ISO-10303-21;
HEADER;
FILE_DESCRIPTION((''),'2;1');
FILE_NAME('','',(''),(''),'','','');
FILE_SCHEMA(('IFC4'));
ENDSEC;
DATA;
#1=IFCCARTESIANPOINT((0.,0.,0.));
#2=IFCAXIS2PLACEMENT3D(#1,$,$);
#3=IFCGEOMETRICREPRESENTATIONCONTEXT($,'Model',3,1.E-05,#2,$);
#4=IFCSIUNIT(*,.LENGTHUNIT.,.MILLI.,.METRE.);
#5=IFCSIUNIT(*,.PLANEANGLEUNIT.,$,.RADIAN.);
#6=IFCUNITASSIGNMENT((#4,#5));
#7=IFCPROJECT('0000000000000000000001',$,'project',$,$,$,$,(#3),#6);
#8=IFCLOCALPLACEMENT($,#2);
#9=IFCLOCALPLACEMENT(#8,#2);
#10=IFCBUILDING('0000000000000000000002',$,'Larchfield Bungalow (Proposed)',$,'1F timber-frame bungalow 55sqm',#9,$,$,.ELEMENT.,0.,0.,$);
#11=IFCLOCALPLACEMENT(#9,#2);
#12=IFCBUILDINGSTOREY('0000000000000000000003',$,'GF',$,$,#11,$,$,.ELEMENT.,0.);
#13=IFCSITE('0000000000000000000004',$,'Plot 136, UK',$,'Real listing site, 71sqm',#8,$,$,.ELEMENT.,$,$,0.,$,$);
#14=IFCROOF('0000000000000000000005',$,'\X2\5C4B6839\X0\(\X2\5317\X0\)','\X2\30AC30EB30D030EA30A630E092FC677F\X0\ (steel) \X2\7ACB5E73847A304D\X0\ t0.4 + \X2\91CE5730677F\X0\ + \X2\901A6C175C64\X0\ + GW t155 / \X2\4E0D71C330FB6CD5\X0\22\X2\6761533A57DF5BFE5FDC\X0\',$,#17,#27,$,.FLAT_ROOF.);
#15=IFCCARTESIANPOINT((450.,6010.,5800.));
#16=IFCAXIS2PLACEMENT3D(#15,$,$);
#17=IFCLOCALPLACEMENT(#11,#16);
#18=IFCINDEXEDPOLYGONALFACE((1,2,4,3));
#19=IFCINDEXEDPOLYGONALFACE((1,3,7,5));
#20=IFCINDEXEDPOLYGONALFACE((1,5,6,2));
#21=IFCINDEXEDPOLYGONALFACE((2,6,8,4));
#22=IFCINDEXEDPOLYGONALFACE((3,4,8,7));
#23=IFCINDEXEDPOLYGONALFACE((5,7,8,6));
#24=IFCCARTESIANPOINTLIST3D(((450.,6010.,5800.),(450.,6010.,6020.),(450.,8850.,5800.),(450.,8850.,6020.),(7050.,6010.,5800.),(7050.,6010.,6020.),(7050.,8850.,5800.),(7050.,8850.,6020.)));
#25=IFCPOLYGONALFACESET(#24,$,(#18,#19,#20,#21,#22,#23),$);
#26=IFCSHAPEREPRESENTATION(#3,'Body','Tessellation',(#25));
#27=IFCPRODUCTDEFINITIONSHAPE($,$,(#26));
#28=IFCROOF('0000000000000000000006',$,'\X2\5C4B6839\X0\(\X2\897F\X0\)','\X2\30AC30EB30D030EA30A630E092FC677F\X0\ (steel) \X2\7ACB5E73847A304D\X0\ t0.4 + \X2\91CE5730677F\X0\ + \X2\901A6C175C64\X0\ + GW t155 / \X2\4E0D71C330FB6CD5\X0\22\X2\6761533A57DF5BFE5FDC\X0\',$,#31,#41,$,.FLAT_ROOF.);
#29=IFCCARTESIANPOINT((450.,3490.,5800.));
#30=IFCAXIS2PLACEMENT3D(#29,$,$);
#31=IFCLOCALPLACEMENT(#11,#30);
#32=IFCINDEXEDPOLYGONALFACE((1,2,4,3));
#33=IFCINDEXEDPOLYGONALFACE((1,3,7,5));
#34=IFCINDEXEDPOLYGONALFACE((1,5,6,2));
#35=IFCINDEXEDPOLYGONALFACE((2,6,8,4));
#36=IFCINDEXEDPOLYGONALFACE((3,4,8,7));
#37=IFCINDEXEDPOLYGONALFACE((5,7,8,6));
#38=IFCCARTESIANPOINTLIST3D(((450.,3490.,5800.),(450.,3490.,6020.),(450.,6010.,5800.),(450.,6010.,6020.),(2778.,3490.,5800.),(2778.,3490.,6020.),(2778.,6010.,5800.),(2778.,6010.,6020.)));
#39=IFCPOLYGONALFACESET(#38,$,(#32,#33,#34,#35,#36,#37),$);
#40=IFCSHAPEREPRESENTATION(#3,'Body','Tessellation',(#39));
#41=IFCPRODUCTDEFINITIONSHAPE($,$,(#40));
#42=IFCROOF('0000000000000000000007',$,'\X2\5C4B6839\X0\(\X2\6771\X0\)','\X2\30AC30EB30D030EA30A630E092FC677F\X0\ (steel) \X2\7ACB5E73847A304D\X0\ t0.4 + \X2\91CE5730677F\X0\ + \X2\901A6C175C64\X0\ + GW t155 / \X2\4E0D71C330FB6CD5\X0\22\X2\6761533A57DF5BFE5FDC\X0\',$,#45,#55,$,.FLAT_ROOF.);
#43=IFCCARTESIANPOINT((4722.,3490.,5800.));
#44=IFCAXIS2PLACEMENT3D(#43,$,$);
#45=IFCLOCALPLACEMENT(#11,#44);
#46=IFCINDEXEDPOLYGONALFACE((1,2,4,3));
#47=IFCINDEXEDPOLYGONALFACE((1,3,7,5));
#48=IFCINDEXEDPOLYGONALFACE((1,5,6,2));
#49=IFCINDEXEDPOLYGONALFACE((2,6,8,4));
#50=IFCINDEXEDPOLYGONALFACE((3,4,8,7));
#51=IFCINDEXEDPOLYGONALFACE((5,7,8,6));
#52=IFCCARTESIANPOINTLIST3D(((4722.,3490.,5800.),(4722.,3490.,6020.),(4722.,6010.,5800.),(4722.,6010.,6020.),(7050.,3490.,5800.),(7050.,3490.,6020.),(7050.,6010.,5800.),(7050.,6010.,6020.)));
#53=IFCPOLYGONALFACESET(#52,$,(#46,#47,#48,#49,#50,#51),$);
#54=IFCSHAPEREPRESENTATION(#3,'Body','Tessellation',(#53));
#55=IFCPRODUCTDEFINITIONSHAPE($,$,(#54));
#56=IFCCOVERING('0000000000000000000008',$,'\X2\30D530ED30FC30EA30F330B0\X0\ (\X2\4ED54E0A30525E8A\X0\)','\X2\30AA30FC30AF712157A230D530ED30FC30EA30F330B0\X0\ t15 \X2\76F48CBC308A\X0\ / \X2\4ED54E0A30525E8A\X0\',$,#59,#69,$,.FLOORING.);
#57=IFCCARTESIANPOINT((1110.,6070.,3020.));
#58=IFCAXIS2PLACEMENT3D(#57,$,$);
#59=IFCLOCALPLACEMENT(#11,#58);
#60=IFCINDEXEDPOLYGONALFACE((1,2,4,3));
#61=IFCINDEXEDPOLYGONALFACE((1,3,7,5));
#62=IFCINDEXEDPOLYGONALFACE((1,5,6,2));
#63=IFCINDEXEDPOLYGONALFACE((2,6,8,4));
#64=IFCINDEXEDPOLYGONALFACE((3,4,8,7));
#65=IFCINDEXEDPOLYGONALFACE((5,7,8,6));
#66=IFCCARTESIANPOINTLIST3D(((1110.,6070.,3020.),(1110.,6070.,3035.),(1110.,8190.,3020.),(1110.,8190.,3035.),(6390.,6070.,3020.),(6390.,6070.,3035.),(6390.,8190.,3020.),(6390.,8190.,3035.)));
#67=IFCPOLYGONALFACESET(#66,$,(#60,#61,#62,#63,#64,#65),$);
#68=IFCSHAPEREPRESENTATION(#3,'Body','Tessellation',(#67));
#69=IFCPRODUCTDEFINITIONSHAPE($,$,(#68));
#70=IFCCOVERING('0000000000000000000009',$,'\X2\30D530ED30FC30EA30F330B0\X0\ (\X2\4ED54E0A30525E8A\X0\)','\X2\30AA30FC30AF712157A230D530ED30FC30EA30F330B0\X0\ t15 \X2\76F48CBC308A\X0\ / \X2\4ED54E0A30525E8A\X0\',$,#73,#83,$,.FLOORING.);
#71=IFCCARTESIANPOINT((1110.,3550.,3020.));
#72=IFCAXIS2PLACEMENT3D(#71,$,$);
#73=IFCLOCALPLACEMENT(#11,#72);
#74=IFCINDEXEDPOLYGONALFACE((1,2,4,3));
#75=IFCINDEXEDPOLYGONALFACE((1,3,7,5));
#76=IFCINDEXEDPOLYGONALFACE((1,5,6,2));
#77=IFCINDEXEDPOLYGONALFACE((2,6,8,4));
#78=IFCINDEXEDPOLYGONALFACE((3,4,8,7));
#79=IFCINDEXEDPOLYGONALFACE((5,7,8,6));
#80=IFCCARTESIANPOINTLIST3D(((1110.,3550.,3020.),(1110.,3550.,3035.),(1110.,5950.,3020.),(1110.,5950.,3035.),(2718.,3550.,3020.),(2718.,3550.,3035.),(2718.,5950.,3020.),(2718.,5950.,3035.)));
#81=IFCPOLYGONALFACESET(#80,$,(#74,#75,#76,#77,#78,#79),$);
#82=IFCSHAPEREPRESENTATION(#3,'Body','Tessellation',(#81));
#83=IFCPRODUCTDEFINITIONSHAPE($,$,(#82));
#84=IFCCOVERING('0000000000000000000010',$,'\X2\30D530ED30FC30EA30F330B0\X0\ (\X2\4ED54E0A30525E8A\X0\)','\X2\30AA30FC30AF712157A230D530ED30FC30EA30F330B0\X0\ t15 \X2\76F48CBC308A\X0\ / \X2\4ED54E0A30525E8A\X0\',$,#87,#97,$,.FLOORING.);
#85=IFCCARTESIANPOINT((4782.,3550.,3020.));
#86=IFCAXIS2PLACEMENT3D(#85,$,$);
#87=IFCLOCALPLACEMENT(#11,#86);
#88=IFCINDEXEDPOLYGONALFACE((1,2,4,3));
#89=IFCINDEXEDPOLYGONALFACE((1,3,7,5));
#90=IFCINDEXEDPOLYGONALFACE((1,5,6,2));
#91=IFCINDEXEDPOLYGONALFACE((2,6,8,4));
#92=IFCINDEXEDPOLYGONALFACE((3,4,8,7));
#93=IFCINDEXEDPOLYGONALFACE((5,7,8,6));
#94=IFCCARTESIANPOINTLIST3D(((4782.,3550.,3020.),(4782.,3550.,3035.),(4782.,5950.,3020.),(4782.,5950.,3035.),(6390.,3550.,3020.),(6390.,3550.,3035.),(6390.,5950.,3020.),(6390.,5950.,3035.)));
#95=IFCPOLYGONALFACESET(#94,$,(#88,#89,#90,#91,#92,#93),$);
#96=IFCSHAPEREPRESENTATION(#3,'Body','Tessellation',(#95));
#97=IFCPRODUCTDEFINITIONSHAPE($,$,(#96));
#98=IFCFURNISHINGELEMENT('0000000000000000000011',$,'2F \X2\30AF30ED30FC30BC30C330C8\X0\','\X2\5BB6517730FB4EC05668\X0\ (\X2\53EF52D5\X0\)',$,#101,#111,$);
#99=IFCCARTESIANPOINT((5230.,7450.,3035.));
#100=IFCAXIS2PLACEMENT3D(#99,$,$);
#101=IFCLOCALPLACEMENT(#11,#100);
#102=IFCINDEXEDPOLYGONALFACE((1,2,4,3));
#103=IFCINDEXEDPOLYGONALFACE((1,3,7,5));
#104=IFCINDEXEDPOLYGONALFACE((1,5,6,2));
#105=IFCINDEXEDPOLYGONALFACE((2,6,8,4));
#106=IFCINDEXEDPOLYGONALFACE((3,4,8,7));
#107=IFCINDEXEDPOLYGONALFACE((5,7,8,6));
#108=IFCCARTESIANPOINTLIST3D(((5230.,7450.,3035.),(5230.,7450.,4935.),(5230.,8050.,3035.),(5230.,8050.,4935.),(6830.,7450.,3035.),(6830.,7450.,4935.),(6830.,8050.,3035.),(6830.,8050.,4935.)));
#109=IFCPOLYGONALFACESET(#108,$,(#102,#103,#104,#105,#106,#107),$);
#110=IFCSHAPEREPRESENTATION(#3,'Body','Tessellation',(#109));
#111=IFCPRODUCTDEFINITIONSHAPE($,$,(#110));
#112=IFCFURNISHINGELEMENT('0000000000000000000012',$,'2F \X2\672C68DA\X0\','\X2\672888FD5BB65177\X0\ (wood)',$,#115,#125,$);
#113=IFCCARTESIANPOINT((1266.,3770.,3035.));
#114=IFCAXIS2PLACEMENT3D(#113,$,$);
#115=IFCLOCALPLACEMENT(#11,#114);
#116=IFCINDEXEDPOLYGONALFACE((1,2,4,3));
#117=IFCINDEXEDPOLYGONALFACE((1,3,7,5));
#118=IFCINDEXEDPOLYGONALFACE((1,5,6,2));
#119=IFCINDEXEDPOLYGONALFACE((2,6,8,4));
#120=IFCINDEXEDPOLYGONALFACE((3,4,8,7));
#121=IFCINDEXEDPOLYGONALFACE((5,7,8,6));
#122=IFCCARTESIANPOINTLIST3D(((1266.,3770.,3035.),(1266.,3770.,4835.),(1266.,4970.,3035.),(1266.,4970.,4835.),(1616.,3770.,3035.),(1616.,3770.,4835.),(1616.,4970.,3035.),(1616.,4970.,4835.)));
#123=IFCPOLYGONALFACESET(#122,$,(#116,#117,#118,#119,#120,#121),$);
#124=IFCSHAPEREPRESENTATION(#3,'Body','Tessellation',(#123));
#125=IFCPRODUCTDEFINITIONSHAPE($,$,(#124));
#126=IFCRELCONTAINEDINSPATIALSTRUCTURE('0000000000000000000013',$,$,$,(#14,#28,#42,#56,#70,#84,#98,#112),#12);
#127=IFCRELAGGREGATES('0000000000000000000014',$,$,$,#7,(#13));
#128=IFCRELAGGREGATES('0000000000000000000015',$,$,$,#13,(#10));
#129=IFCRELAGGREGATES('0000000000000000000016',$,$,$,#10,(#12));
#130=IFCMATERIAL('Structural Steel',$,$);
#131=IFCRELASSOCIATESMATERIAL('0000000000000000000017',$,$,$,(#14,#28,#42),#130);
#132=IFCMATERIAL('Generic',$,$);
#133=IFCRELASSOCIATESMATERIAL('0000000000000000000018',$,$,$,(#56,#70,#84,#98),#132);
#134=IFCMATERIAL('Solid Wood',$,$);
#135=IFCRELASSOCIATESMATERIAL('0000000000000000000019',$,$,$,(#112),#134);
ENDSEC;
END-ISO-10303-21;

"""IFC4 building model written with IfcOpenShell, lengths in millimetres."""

from ifc_helpers import new_model, si_unit, frame, frame_2d, origin, place, context, project, spatial, rectangle, extrude, material, element, save


model = new_model("IFC4")

# Units and contexts
model_context = context("Model", 3, precision=1e-05, world=origin())
ifc_project = project(units=[si_unit("LENGTHUNIT", "METRE", prefix="MILLI"), si_unit("PLANEANGLEUNIT", "RADIAN")], contexts=[model_context])

# Site, building, storey
site_placement = place(None, origin())
site = spatial("IfcSite", under=ifc_project, at=site_placement, Name="Plot 136, UK", ObjectType="Real listing site, 71sqm", CompositionType="ELEMENT", RefElevation=0.0)
building_placement = place(site_placement, origin())
building = spatial("IfcBuilding", under=site, at=building_placement, Name="Larchfield Bungalow (Proposed)", ObjectType="1F timber-frame bungalow 55sqm", CompositionType="ELEMENT", ElevationOfRefHeight=0.0, ElevationOfTerrain=0.0)
storey_placement = place(building_placement, origin())
storey = spatial("IfcBuildingStorey", under=building, at=storey_placement, Name="GF", CompositionType="ELEMENT", Elevation=0.0)

# Shared definitions
ifc_material_1 = material(Name="Solid Wood")

# Shared definitions
ifc_material_2 = material(Name="Generic")

# Roofs
ifc_material_3 = material(Name="Structural Steel")
for number, where, name in (
    (1, (450.0, 6010.0, 5800.0), "屋根(北)"),
):
    element("IfcRoof", number, at=place(storey_placement, frame(where)), inside=storey, material=ifc_material_3, Name=name, Description="ガルバリウム鋼板 (steel) 立平葺き t0.4 + 野地板 + 通気層 + GW t155 / 不燃・法22条区域対応", PredefinedType="FLAT_ROOF", context=model_context, shape_type="SweptSolid", body=[
        extrude(rectangle(XDim=6600.0, YDim=2840.0, at=frame_2d((3300.0, 1420.0))), frame((450.0, 6010.0, 5800.0)), (0.0, 0.0, 1.0), 220.0),
    ])
roof_1_placement = place(storey_placement, frame((450.0, 3490.0, 5800.0)))
element("IfcRoof", 2, at=roof_1_placement, inside=storey, material=ifc_material_3, Name="屋根(西)", Description="ガルバリウム鋼板 (steel) 立平葺き t0.4 + 野地板 + 通気層 + GW t155 / 不燃・法22条区域対応", PredefinedType="FLAT_ROOF", context=model_context, shape_type="SweptSolid", body=[
    extrude(rectangle(XDim=2328.0, YDim=2520.0, at=frame_2d((1164.0, 1260.0))), frame((450.0, 3490.0, 5800.0)), (0.0, 0.0, 1.0), 220.0),
])
roof_2_placement = place(storey_placement, frame((4722.0, 3490.0, 5800.0)))
element("IfcRoof", 3, at=roof_2_placement, inside=storey, material=ifc_material_3, Name="屋根(東)", Description="ガルバリウム鋼板 (steel) 立平葺き t0.4 + 野地板 + 通気層 + GW t155 / 不燃・法22条区域対応", PredefinedType="FLAT_ROOF", context=model_context, shape_type="SweptSolid", body=[
    extrude(rectangle(XDim=2328.0, YDim=2520.0, at=frame_2d((1164.0, 1260.0))), frame((4722.0, 3490.0, 5800.0)), (0.0, 0.0, 1.0), 220.0),
])

# Coverings
covering_1_placement = place(storey_placement, frame((1110.0, 6070.0, 3020.0)))
element("IfcCovering", 4, at=covering_1_placement, inside=storey, material=ifc_material_2, Name="フローリング (仕上げ床)", Description="オーク無垢フローリング t15 直貼り / 仕上げ床", PredefinedType="FLOORING", context=model_context, shape_type="SweptSolid", body=[
    extrude(rectangle(XDim=5280.0, YDim=2120.0, at=frame_2d((2640.0, 1060.0))), frame((1110.0, 6070.0, 3020.0)), (0.0, 0.0, 1.0), 15.0),
])
covering_2_placement = place(storey_placement, frame((1110.0, 3550.0, 3020.0)))
element("IfcCovering", 5, at=covering_2_placement, inside=storey, material=ifc_material_2, Name="フローリング (仕上げ床)", Description="オーク無垢フローリング t15 直貼り / 仕上げ床", PredefinedType="FLOORING", context=model_context, shape_type="SweptSolid", body=[
    extrude(rectangle(XDim=1608.0, YDim=2400.0, at=frame_2d((804.0, 1200.0))), frame((1110.0, 3550.0, 3020.0)), (0.0, 0.0, 1.0), 15.0),
])
covering_3_placement = place(storey_placement, frame((4782.0, 3550.0, 3020.0)))
element("IfcCovering", 6, at=covering_3_placement, inside=storey, material=ifc_material_2, Name="フローリング (仕上げ床)", Description="オーク無垢フローリング t15 直貼り / 仕上げ床", PredefinedType="FLOORING", context=model_context, shape_type="SweptSolid", body=[
    extrude(rectangle(XDim=1608.0, YDim=2400.0, at=frame_2d((804.0, 1200.0))), frame((4782.0, 3550.0, 3020.0)), (0.0, 0.0, 1.0), 15.0),
])

# Furnishing elements
furnishing_1_placement = place(storey_placement, frame((5230.0, 7450.0, 3035.0)))
element("IfcFurnishingElement", 7, at=furnishing_1_placement, inside=storey, material=ifc_material_2, Name="2F クローゼット", Description="家具・什器 (可動)", context=model_context, shape_type="SweptSolid", body=[
    extrude(rectangle(XDim=1600.0, YDim=600.0, at=frame_2d((800.0, 300.0))), frame((5230.0, 7450.0, 3035.0)), (0.0, 0.0, 1.0), 1900.0),
])
furnishing_2_placement = place(storey_placement, frame((1266.0, 3770.0, 3035.0)))
element("IfcFurnishingElement", 8, at=furnishing_2_placement, inside=storey, material=ifc_material_1, Name="2F 本棚", Description="木製家具 (wood)", context=model_context, shape_type="SweptSolid", body=[
    extrude(rectangle(XDim=350.0, YDim=1200.0, at=frame_2d((175.0, 600.0))), frame((1266.0, 3770.0, 3035.0)), (0.0, 0.0, 1.0), 1800.0),
])

save(model, "model.ifc")
